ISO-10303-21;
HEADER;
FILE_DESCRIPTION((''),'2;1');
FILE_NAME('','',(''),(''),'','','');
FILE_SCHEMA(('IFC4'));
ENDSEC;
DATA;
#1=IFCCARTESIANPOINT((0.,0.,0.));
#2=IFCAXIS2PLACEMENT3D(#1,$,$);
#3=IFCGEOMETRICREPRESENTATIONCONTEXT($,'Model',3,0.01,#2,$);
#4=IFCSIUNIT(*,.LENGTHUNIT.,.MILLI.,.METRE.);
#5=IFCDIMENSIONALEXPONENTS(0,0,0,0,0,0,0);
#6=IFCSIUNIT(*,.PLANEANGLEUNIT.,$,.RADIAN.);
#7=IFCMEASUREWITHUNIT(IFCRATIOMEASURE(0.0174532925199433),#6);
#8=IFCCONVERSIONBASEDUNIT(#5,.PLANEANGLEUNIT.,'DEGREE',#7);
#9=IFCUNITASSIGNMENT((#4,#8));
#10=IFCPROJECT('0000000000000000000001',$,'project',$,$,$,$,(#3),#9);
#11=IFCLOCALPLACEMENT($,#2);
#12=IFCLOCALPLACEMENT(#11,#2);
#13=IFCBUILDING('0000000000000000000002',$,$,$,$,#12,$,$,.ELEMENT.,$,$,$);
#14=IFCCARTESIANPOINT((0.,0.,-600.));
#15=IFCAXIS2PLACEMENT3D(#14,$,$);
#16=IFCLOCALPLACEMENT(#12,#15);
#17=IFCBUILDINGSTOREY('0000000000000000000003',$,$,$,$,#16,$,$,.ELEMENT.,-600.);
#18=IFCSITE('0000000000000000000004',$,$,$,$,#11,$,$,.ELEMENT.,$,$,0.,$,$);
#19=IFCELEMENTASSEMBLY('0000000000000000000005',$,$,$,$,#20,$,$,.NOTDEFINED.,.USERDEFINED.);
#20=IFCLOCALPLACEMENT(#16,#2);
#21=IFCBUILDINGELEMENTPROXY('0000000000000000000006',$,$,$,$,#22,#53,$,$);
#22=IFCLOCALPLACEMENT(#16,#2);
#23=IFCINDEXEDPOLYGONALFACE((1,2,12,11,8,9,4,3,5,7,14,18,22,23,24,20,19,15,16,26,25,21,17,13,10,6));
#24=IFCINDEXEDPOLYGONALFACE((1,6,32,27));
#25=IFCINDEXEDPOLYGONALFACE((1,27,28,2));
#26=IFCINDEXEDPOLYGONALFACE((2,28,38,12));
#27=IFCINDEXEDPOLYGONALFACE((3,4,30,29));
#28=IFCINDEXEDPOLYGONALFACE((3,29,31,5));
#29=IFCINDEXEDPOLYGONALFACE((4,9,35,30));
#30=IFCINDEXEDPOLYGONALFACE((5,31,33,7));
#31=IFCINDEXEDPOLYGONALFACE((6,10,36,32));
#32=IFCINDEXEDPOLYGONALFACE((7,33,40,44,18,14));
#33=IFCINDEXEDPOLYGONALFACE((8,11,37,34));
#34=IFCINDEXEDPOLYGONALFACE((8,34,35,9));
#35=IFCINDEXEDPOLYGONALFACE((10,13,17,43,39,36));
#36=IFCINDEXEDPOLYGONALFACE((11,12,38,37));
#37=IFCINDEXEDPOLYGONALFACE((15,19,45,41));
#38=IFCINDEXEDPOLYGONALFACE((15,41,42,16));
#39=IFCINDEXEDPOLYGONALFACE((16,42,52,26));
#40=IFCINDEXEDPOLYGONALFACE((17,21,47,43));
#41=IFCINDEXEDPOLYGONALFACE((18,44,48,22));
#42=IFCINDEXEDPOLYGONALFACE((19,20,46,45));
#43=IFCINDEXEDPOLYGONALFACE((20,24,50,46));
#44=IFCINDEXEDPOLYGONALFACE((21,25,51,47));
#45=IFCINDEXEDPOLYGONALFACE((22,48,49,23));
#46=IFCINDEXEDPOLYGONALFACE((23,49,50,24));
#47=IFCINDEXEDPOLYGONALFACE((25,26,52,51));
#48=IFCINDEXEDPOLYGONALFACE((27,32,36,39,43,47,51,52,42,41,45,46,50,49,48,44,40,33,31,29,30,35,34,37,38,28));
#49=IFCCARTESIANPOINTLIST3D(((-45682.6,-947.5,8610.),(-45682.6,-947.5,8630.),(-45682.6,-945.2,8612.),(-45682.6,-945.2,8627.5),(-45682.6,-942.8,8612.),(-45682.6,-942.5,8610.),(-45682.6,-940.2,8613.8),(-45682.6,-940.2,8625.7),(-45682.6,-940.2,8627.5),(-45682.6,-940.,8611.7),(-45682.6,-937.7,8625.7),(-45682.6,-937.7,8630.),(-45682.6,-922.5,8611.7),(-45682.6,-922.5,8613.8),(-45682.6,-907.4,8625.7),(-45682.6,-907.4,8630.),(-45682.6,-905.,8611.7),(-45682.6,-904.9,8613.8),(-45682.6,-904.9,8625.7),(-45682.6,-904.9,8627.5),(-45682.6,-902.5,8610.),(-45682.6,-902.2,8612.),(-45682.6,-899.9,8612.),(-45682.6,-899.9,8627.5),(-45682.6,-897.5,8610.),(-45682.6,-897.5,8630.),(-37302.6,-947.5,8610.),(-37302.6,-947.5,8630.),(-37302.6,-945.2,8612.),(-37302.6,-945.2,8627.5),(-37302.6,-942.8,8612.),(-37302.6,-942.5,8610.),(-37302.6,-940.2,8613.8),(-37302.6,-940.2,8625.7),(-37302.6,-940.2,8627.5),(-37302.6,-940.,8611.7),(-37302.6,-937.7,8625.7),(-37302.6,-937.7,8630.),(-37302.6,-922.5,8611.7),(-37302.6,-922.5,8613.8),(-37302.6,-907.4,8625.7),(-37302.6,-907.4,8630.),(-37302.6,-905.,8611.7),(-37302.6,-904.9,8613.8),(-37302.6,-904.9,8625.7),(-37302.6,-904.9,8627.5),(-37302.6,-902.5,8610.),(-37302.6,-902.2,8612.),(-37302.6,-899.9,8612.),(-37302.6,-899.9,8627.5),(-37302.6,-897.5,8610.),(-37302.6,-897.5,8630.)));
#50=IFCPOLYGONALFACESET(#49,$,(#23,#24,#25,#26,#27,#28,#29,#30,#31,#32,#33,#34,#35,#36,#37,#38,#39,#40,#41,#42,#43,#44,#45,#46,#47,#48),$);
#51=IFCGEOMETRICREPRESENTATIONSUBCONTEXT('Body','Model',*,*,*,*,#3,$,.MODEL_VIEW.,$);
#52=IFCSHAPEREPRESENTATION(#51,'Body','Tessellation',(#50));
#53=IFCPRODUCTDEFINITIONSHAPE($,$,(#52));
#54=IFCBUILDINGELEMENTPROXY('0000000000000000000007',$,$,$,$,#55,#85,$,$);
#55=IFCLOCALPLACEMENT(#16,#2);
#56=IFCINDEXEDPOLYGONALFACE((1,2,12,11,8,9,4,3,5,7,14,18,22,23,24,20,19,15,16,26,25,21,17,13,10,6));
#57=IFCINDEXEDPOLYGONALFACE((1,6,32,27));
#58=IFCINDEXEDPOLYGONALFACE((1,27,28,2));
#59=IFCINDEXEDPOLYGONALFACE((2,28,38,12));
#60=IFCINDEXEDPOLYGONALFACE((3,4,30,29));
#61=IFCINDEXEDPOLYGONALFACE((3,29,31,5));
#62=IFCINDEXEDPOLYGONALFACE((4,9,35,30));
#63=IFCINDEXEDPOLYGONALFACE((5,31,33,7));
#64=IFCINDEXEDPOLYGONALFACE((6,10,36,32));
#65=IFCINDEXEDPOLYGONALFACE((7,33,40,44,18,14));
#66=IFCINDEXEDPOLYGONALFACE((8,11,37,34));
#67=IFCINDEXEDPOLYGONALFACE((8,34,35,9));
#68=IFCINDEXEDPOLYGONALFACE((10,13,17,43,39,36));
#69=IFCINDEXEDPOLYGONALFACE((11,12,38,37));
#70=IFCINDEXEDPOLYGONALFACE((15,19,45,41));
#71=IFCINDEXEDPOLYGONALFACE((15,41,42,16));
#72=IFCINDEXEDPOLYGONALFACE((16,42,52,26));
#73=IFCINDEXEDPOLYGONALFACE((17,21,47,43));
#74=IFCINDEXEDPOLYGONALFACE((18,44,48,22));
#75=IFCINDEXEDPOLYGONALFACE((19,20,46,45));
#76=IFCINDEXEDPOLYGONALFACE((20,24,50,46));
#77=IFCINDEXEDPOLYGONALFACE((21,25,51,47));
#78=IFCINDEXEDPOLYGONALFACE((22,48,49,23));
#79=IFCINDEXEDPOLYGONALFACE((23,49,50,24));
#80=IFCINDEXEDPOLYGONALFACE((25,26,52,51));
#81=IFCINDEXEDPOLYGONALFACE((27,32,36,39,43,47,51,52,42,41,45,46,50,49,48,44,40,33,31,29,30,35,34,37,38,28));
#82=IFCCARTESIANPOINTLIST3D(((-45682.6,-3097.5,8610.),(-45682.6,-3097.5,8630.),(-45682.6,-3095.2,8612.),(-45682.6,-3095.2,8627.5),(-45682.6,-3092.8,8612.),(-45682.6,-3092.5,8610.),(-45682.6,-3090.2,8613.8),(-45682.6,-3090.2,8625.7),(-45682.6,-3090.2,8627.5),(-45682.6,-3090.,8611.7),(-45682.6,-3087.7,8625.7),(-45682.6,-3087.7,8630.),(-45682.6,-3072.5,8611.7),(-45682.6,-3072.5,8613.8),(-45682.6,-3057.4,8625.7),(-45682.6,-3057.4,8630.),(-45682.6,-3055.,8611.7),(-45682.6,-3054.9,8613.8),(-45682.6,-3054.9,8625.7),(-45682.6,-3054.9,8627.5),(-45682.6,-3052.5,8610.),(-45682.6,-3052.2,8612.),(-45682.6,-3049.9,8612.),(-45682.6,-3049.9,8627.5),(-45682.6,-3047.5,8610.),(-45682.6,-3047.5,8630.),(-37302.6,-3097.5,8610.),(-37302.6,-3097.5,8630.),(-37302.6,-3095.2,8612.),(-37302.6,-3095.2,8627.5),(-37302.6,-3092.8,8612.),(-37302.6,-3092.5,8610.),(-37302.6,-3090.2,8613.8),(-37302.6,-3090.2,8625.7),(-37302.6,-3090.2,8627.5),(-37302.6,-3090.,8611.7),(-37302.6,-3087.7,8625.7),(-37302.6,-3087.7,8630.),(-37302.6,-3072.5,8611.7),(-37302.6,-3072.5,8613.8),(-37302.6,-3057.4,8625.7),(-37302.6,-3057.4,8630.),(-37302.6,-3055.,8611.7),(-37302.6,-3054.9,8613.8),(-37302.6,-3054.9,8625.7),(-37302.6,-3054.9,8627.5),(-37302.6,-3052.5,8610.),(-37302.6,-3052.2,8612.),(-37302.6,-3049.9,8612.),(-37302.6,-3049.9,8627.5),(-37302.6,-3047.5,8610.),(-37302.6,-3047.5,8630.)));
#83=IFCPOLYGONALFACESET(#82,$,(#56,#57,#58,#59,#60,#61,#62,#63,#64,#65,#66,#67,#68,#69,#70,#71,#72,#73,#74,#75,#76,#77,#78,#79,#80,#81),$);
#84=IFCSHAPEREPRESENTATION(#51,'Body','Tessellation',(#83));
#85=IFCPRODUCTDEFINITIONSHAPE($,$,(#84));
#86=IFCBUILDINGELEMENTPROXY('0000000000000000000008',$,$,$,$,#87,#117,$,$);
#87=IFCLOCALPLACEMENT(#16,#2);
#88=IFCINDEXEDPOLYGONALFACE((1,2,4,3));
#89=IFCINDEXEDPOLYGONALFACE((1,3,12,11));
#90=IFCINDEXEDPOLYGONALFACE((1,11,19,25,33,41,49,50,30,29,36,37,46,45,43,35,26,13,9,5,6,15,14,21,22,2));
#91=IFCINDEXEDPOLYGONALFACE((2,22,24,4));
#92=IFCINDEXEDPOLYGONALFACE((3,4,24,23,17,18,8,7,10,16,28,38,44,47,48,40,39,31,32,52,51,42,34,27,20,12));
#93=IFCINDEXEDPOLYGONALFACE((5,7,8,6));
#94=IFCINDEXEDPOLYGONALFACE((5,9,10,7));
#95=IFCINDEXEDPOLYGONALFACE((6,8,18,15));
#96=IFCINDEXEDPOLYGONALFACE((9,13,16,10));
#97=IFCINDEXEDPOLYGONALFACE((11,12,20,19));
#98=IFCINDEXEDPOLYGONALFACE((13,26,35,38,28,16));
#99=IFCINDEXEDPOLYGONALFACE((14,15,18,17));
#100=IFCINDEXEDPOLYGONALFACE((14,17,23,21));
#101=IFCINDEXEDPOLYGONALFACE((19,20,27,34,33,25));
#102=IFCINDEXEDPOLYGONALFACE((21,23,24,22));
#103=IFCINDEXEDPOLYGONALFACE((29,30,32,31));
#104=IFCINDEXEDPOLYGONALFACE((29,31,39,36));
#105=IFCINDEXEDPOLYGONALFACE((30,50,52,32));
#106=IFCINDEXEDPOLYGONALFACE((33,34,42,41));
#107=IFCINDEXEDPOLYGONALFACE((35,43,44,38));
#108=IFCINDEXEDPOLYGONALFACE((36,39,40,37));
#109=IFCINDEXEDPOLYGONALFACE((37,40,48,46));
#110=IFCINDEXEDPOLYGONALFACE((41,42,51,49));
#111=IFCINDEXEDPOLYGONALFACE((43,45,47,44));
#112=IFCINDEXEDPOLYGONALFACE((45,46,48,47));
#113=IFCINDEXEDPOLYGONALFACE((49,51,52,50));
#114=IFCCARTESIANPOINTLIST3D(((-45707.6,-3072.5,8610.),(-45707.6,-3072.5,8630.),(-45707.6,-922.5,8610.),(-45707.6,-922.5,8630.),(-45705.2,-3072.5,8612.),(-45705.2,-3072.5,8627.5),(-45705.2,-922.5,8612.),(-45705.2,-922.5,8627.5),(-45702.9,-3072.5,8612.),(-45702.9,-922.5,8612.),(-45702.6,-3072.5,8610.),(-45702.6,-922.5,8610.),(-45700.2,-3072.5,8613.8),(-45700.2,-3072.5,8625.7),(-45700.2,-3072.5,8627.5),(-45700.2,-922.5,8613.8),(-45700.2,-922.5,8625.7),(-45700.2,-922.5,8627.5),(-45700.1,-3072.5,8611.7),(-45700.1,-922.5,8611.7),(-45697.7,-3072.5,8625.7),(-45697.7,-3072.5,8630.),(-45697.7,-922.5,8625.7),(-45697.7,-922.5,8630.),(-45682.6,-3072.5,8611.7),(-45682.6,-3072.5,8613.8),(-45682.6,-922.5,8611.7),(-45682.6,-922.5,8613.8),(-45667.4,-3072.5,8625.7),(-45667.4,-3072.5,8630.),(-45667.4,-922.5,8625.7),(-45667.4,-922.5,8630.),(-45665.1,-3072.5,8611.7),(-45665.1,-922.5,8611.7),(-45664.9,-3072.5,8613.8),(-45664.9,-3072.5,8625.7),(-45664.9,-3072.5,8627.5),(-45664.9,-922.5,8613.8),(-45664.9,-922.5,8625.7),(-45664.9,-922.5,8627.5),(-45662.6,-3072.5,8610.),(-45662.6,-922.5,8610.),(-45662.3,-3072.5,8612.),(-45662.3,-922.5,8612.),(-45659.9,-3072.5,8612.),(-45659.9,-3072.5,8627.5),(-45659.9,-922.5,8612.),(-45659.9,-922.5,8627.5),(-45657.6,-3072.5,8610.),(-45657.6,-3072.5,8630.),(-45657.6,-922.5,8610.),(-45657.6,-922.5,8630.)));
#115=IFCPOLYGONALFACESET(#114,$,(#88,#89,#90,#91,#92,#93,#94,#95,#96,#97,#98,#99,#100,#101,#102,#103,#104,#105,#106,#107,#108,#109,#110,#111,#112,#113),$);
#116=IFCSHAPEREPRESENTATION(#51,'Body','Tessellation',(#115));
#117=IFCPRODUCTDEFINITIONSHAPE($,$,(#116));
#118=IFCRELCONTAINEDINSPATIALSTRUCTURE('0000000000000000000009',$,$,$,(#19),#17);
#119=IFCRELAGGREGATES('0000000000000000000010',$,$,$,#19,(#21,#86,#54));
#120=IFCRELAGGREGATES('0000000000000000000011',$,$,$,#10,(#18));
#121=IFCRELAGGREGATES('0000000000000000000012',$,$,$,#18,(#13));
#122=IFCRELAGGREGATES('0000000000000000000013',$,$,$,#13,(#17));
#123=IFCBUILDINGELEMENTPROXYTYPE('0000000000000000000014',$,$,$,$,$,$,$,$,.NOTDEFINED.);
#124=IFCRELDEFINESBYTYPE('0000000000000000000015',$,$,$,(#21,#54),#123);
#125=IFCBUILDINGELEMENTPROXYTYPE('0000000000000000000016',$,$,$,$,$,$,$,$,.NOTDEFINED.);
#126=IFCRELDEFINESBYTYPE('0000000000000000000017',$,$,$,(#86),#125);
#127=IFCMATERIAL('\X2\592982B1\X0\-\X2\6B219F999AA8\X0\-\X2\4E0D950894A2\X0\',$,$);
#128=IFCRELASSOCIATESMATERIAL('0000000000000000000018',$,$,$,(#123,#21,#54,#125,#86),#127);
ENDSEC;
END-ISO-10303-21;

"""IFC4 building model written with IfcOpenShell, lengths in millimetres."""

from ifc_helpers import new_model, entity, si_unit, converted_unit, frame, origin, place, context, subcontext, project, spatial, polyline, outline, extrude, source, transform, mapped, material, type_object, type_shapes, element, aggregate, save


model = new_model("IFC4")

# Units and contexts
model_context = context("Model", 3, precision=0.01, world=origin())
body_context = subcontext(model_context, "Body", "Model", "MODEL_VIEW")
ifc_project = project(units=[si_unit("LENGTHUNIT", "METRE", prefix="MILLI"), converted_unit("PLANEANGLEUNIT", "DEGREE", entity("IfcRatioMeasure", 0.0174532925199433), si_unit("PLANEANGLEUNIT", "RADIAN"), dimensions=[0, 0, 0, 0, 0, 0, 0])], contexts=[model_context])

# Site, building, storey
site_placement = place(None, origin())
site = spatial("IfcSite", under=ifc_project, at=site_placement, CompositionType="ELEMENT", RefElevation=0.0)
building_placement = place(site_placement, origin())
building = spatial("IfcBuilding", under=site, at=building_placement, CompositionType="ELEMENT")
storey_placement = place(building_placement, frame((0.0, 0.0, -600.0)))
storey = spatial("IfcBuildingStorey", under=building, at=storey_placement, CompositionType="ELEMENT", Elevation=-600.0)

# Element assembly, building element proxies
assembly_1_placement = place(storey_placement, origin())
assembly_1 = element("IfcElementAssembly", 1, at=assembly_1_placement, inside=storey, AssemblyPlace="NOTDEFINED", PredefinedType="USERDEFINED")
ifc_material_1 = material(Name="天花-次龙骨-不锈钢")
building_element_proxy_type_1 = type_object("IfcBuildingElementProxyType", PredefinedType="NOTDEFINED", material=ifc_material_1)
shared_shape_1 = source(origin(), body_context, "Body", "SweptSolid", [
    extrude(outline(polyline([(-25.0, -9.1), (-20.0, -9.1), (-17.5, -7.4), (0.0, -7.4), (17.5, -7.4), (20.0, -9.1), (25.0, -9.1), (25.0, 10.9), (15.1, 10.9), (15.1, 6.6), (17.6, 6.6), (17.6, 8.4), (22.6, 8.4), (22.6, -7.1), (20.3, -7.1), (17.6, -5.3), (0.0, -5.3), (-17.6, -5.3), (-20.3, -7.1), (-22.6, -7.1), (-22.6, 8.4), (-17.6, 8.4), (-17.6, 6.6), (-15.1, 6.6), (-15.1, 10.9), (-25.0, 10.9), (-25.0, -9.1)])), frame((0.0, 0.0, -0.9), z_axis=(1.0, 0.0, 0.0), x_axis=(0.0, 1.0, 0.0)), (0.0, 0.0, 1.0), 8380.0),
])
type_shapes(building_element_proxy_type_1, [shared_shape_1])
proxy_1_placement = place(assembly_1_placement, frame((-45682.6, -922.5, 8620.0)))
proxy_1 = element("IfcBuildingElementProxy", 2, at=proxy_1_placement, type_object=building_element_proxy_type_1, material=ifc_material_1, context=body_context, shape_type="MappedRepresentation", body=[
    mapped(shared_shape_1, transform((0.0, 0.0, 0.0), scale=1.0)),
])
proxy_2_placement = place(assembly_1_placement, frame((-45682.6, -3072.5, 8620.0)))
proxy_2 = element("IfcBuildingElementProxy", 3, at=proxy_2_placement, type_object=building_element_proxy_type_1, material=ifc_material_1, context=body_context, shape_type="MappedRepresentation", body=[
    mapped(shared_shape_1, transform((0.0, 0.0, 0.0), scale=1.0)),
])
building_element_proxy_type_2 = type_object("IfcBuildingElementProxyType", PredefinedType="NOTDEFINED", material=ifc_material_1)
shared_shape_2 = source(origin(), body_context, "Body", "SweptSolid", [
    extrude(outline(polyline([(-25.0, -9.1), (-20.0, -9.1), (-17.5, -7.4), (0.0, -7.4), (17.5, -7.4), (20.0, -9.1), (25.0, -9.1), (25.0, 10.9), (15.1, 10.9), (15.1, 6.6), (17.6, 6.6), (17.6, 8.4), (22.6, 8.4), (22.6, -7.1), (20.3, -7.1), (17.6, -5.3), (0.0, -5.3), (-17.6, -5.3), (-20.3, -7.1), (-22.6, -7.1), (-22.6, 8.4), (-17.6, 8.4), (-17.6, 6.6), (-15.1, 6.6), (-15.1, 10.9), (-25.0, 10.9), (-25.0, -9.1)])), frame((0.0, 0.0, -0.9), z_axis=(1.0, 0.0, 0.0), x_axis=(0.0, 1.0, 0.0)), (0.0, 0.0, 1.0), 2150.0),
])
type_shapes(building_element_proxy_type_2, [shared_shape_2])
proxy_3_placement = place(assembly_1_placement, frame((-45682.6, -922.5, 8620.0), z_axis=(0.0, 0.0, 1.0), x_axis=(0.0, -1.0, 0.0)))
proxy_3 = element("IfcBuildingElementProxy", 4, at=proxy_3_placement, type_object=building_element_proxy_type_2, material=ifc_material_1, context=body_context, shape_type="MappedRepresentation", body=[
    mapped(shared_shape_2, transform((0.0, 0.0, 0.0), scale=1.0)),
])
aggregate(assembly_1, [proxy_1, proxy_3, proxy_2])

save(model, "model.ifc")
